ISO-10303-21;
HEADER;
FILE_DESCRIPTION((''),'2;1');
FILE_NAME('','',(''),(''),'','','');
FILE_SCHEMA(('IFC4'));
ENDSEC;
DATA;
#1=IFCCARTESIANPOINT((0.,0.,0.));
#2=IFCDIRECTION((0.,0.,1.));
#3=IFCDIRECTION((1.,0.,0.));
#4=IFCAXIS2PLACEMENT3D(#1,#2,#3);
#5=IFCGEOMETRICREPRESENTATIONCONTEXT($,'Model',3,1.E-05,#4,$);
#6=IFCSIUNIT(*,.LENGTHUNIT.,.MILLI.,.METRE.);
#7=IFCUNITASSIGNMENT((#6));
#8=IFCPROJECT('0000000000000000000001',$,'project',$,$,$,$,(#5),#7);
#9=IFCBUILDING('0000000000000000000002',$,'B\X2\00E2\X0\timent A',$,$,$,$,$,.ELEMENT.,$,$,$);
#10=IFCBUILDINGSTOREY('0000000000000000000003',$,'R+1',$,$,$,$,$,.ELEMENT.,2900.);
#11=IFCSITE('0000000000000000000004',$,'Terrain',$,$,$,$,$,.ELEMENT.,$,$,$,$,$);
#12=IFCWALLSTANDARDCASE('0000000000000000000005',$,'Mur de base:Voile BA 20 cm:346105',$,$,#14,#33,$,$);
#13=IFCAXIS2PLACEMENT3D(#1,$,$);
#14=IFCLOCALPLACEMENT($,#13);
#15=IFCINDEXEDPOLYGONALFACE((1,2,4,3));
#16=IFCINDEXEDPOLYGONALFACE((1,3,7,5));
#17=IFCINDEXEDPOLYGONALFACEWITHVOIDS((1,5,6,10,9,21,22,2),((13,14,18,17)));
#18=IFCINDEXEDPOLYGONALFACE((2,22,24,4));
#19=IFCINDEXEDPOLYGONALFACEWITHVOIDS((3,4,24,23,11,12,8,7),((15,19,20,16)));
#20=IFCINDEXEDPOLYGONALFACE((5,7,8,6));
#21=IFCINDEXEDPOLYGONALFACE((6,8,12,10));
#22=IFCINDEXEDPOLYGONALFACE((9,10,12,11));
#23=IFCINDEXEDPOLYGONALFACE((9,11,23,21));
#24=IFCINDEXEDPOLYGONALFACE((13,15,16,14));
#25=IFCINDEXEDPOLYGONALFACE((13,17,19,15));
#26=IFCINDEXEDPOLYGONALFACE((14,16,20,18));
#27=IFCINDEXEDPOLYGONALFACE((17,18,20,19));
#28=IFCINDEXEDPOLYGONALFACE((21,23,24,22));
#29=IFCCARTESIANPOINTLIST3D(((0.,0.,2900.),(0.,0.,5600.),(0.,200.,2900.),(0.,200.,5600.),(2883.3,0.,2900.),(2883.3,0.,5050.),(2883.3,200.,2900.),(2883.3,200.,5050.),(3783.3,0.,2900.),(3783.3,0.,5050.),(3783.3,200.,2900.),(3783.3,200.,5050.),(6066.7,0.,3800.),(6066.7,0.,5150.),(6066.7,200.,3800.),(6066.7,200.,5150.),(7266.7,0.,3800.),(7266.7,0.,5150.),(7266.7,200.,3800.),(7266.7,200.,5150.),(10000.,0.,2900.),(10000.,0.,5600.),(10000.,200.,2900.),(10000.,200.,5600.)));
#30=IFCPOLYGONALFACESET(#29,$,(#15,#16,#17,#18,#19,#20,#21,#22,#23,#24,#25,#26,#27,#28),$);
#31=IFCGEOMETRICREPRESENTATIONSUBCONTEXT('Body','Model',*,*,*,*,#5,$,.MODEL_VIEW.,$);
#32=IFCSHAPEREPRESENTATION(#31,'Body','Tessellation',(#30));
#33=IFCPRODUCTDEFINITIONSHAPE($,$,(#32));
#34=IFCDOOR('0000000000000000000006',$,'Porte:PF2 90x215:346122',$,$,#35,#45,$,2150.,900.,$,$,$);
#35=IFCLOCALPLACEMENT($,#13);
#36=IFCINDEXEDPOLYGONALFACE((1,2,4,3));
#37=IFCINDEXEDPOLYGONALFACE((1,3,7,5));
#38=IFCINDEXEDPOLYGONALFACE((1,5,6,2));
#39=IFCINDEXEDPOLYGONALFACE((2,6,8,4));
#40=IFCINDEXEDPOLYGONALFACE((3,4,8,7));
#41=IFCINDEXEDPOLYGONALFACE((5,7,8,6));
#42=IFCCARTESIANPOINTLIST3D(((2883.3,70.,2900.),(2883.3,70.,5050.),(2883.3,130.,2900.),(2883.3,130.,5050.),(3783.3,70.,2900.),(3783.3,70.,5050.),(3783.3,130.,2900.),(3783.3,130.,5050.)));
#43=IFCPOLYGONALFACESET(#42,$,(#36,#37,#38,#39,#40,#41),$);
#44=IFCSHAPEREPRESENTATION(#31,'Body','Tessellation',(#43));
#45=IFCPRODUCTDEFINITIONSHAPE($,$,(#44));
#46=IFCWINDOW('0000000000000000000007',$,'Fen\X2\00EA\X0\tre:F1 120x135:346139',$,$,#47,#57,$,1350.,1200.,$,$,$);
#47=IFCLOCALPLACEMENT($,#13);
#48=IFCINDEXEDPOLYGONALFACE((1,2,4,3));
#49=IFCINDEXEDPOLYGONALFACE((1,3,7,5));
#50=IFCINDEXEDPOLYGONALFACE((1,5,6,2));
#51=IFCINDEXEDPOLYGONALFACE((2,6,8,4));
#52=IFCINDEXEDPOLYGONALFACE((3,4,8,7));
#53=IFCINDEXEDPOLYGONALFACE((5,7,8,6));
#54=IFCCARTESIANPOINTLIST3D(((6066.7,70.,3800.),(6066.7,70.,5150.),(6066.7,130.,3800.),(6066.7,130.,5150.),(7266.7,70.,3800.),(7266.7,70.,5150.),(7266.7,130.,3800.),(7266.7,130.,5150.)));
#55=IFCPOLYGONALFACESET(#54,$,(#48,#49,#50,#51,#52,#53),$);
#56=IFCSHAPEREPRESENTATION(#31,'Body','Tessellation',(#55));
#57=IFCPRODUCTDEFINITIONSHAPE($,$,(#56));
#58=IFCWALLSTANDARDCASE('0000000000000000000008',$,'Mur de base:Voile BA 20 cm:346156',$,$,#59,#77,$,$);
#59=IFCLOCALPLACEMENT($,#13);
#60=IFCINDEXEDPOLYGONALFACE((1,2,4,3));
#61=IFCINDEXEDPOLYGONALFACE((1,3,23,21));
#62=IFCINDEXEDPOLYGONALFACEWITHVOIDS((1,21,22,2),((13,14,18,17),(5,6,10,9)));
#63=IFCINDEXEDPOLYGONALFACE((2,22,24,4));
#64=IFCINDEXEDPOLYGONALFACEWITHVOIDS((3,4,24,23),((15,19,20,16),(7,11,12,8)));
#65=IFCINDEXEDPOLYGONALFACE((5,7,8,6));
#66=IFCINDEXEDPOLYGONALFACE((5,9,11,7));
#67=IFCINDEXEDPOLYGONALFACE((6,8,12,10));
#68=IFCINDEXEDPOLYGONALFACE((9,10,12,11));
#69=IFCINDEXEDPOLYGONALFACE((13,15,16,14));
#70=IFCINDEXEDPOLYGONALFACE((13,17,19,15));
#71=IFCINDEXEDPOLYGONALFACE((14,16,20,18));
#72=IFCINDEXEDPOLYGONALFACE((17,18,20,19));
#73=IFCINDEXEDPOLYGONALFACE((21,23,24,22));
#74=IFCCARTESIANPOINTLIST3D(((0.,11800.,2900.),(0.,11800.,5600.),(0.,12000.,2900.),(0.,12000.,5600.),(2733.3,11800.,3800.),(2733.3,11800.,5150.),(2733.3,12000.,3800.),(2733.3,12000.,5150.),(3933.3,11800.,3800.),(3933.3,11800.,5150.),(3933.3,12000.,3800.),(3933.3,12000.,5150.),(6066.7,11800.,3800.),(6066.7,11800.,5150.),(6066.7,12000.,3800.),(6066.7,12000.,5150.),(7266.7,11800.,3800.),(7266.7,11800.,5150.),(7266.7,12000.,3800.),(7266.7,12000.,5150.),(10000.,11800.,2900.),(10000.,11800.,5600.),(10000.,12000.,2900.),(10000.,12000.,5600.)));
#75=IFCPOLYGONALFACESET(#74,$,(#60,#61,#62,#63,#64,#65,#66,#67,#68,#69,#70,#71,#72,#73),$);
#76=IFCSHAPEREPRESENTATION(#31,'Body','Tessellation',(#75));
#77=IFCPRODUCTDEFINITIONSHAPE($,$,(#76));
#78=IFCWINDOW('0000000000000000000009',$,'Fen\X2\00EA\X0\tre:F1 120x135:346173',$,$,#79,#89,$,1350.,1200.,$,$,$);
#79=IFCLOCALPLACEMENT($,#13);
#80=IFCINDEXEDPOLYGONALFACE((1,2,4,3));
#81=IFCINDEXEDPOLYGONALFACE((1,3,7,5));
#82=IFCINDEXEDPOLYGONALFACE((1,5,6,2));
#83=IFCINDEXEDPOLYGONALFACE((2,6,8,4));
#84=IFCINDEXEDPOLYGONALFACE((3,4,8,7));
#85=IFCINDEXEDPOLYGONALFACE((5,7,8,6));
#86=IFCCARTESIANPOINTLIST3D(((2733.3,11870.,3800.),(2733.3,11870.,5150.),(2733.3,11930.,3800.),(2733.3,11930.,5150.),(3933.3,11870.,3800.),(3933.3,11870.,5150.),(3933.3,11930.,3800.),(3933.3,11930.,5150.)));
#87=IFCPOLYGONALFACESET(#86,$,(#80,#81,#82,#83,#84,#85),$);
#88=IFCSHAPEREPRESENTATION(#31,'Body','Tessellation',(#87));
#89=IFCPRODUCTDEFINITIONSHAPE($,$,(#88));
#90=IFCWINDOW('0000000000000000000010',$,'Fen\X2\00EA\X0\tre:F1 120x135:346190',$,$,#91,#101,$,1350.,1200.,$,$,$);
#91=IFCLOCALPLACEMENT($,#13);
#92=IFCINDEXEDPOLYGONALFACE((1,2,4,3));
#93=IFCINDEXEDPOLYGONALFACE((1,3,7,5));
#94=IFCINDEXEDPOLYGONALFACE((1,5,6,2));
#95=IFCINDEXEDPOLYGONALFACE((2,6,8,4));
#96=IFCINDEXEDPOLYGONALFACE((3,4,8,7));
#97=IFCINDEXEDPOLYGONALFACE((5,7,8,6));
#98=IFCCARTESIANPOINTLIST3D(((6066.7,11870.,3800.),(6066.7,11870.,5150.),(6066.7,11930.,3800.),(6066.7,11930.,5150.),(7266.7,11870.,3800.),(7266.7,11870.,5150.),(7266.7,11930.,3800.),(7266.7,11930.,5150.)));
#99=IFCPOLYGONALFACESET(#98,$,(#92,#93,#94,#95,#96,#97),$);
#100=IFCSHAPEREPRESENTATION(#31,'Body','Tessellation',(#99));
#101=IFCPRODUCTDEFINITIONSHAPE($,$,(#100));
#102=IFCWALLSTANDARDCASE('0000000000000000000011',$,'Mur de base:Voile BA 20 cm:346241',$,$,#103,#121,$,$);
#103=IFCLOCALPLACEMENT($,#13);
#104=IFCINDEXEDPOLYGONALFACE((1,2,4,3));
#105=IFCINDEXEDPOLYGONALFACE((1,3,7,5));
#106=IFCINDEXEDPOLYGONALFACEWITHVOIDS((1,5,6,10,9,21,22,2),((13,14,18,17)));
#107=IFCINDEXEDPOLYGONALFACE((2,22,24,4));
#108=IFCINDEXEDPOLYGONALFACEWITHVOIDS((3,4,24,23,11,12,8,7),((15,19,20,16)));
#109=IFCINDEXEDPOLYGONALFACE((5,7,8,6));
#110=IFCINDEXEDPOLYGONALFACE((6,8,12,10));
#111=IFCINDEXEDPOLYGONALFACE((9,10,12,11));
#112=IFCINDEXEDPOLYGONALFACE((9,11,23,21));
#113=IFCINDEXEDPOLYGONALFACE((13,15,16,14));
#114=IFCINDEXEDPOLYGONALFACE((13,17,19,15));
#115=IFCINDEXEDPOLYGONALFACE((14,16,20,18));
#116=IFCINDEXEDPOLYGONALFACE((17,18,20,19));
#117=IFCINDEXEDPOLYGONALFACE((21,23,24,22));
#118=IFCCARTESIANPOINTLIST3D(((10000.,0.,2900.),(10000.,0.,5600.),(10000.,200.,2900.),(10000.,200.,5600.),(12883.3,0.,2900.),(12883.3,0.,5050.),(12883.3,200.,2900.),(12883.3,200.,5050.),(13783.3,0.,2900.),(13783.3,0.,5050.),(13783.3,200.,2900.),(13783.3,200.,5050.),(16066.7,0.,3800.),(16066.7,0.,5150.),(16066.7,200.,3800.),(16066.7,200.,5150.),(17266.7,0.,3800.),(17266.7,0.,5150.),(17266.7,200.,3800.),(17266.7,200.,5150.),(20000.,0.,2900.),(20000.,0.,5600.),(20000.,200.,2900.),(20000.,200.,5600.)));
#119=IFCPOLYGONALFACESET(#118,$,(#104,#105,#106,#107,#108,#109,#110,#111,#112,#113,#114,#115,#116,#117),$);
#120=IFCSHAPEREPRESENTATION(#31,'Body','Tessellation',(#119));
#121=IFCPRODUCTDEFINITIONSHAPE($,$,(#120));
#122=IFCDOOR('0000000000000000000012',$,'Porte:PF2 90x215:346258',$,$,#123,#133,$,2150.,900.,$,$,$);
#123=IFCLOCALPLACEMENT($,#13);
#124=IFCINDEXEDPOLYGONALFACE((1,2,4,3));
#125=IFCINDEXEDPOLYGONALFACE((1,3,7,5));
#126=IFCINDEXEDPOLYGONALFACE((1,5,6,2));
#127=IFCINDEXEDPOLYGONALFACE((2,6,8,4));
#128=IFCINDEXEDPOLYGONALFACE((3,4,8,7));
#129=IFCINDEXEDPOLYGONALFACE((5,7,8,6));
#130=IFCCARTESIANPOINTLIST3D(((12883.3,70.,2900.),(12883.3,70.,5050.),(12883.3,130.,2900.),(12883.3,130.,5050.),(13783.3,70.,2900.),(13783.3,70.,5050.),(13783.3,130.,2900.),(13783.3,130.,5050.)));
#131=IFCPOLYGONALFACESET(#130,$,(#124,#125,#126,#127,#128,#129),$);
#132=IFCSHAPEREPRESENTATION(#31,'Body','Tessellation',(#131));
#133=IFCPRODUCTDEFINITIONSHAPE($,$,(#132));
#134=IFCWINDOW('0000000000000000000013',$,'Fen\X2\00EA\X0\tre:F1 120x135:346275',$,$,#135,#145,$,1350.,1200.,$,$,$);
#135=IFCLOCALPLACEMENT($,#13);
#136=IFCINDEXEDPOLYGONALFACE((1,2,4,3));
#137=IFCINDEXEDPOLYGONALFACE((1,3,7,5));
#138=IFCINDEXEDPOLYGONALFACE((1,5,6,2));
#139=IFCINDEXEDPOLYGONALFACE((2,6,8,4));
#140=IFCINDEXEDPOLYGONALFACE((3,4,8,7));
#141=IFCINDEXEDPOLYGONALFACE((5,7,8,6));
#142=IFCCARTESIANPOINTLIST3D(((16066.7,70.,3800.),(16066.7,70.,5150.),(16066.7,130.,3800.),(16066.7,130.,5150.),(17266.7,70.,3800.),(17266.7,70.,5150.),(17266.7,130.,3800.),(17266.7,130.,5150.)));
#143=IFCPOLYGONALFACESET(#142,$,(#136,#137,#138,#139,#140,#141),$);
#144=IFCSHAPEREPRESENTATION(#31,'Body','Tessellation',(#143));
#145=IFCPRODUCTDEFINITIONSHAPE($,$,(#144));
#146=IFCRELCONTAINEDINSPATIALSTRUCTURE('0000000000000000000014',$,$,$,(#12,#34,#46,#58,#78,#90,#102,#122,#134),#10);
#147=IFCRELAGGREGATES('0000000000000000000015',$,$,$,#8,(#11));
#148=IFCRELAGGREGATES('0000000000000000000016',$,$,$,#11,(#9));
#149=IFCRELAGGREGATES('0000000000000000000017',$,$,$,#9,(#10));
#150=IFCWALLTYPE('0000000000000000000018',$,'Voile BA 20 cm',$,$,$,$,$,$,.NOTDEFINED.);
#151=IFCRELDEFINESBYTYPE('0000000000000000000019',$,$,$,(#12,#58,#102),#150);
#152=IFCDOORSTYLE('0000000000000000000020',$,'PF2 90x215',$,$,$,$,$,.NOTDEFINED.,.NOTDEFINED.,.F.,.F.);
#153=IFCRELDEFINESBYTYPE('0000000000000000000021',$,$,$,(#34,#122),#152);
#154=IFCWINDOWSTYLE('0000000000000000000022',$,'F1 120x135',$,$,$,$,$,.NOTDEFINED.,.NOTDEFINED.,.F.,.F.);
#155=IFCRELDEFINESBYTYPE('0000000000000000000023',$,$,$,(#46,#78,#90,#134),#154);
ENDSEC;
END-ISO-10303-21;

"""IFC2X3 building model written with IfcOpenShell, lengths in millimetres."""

from ifc_helpers import new_model, si_unit, frame, frame_2d, origin_with_axes, place, context, subcontext, project, spatial, rectangle, extrude, type_object, element, fill, save


model = new_model("IFC2X3")

# Units and contexts
model_context = context("Model", 3, precision=1e-05, world=origin_with_axes())
body_context = subcontext(model_context, "Body", "Model", "MODEL_VIEW")
ifc_project = project(units=[si_unit("LENGTHUNIT", "METRE", prefix="MILLI")], contexts=[model_context])

# Site, building, storey
site = spatial("IfcSite", under=ifc_project, Name="Terrain", CompositionType="ELEMENT")
building = spatial("IfcBuilding", under=site, Name="Bâtiment A", CompositionType="ELEMENT")
storey = spatial("IfcBuildingStorey", under=building, Name="R+1", CompositionType="ELEMENT", Elevation=2900.0)

# Wall, openings, door, window
wall_type_1 = type_object("IfcWallType", Name="Voile BA 20 cm", PredefinedType="NOTDEFINED")
wall_1_placement = place(None, origin_with_axes())
wall_1 = element("IfcWallStandardCase", 1, at=wall_1_placement, inside=storey, type_object=wall_type_1, Name="Mur de base:Voile BA 20 cm:346105", context=body_context, shape_type="SweptSolid", body=[
    extrude(rectangle(XDim=10000.0, YDim=200.0, at=frame_2d((5000.0, 100.0))), frame((0.0, 0.0, 2900.0), z_axis=(0.0, 0.0, 1.0), x_axis=(1.0, 0.0, 0.0)), (0.0, 0.0, 1.0), 2700.0),
])
opening_1_placement = place(None, origin_with_axes())
opening_1 = element("IfcOpeningElement", 2, at=opening_1_placement, cuts=wall_1, context=body_context, shape_type="SweptSolid", body=[
    extrude(rectangle(XDim=900.0, YDim=320.0, at=frame_2d((3333.3, 100.0))), frame((0.0, 0.0, 2900.0), z_axis=(0.0, 0.0, 1.0), x_axis=(1.0, 0.0, 0.0)), (0.0, 0.0, 1.0), 2150.0),
])
opening_2_placement = place(None, origin_with_axes())
opening_2 = element("IfcOpeningElement", 3, at=opening_2_placement, cuts=wall_1, context=body_context, shape_type="SweptSolid", body=[
    extrude(rectangle(XDim=1200.0, YDim=320.0, at=frame_2d((6666.7, 100.0))), frame((0.0, 0.0, 3800.0), z_axis=(0.0, 0.0, 1.0), x_axis=(1.0, 0.0, 0.0)), (0.0, 0.0, 1.0), 1350.0),
])
door_style = type_object("IfcDoorStyle", Name="PF2 90x215", ConstructionType="NOTDEFINED", OperationType="NOTDEFINED", ParameterTakesPrecedence=False, Sizeable=False)
door_1_placement = place(None, origin_with_axes())
door_1 = element("IfcDoor", 4, at=door_1_placement, inside=storey, type_object=door_style, Name="Porte:PF2 90x215:346122", OverallHeight=2150.0, OverallWidth=900.0, context=body_context, shape_type="SweptSolid", body=[
    extrude(rectangle(XDim=900.0, YDim=60.0, at=frame_2d((3333.3, 100.0))), frame((0.0, 0.0, 2900.0), z_axis=(0.0, 0.0, 1.0), x_axis=(1.0, 0.0, 0.0)), (0.0, 0.0, 1.0), 2150.0),
])
fill(opening_1, door_1)
window_style = type_object("IfcWindowStyle", Name="F1 120x135", ConstructionType="NOTDEFINED", OperationType="NOTDEFINED", ParameterTakesPrecedence=False, Sizeable=False)
window_1_placement = place(None, origin_with_axes())
window_1 = element("IfcWindow", 5, at=window_1_placement, inside=storey, type_object=window_style, Name="Fenêtre:F1 120x135:346139", OverallHeight=1350.0, OverallWidth=1200.0, context=body_context, shape_type="SweptSolid", body=[
    extrude(rectangle(XDim=1200.0, YDim=60.0, at=frame_2d((6666.7, 100.0))), frame((0.0, 0.0, 3800.0), z_axis=(0.0, 0.0, 1.0), x_axis=(1.0, 0.0, 0.0)), (0.0, 0.0, 1.0), 1350.0),
])
fill(opening_2, window_1)

# Wall, openings, windows
wall_2_placement = place(None, origin_with_axes())
wall_2 = element("IfcWallStandardCase", 6, at=wall_2_placement, inside=storey, type_object=wall_type_1, Name="Mur de base:Voile BA 20 cm:346156", context=body_context, shape_type="SweptSolid", body=[
    extrude(rectangle(XDim=10000.0, YDim=200.0, at=frame_2d((5000.0, 11900.0))), frame((0.0, 0.0, 2900.0), z_axis=(0.0, 0.0, 1.0), x_axis=(1.0, 0.0, 0.0)), (0.0, 0.0, 1.0), 2700.0),
])
opening_3_placement = place(None, origin_with_axes())
opening_3 = element("IfcOpeningElement", 7, at=opening_3_placement, cuts=wall_2, context=body_context, shape_type="SweptSolid", body=[
    extrude(rectangle(XDim=1200.0, YDim=320.0, at=frame_2d((3333.3, 11900.0))), frame((0.0, 0.0, 3800.0), z_axis=(0.0, 0.0, 1.0), x_axis=(1.0, 0.0, 0.0)), (0.0, 0.0, 1.0), 1350.0),
])
opening_4_placement = place(None, origin_with_axes())
opening_4 = element("IfcOpeningElement", 8, at=opening_4_placement, cuts=wall_2, context=body_context, shape_type="SweptSolid", body=[
    extrude(rectangle(XDim=1200.0, YDim=320.0, at=frame_2d((6666.7, 11900.0))), frame((0.0, 0.0, 3800.0), z_axis=(0.0, 0.0, 1.0), x_axis=(1.0, 0.0, 0.0)), (0.0, 0.0, 1.0), 1350.0),
])
window_2_placement = place(None, origin_with_axes())
window_2 = element("IfcWindow", 9, at=window_2_placement, inside=storey, type_object=window_style, Name="Fenêtre:F1 120x135:346173", OverallHeight=1350.0, OverallWidth=1200.0, context=body_context, shape_type="SweptSolid", body=[
    extrude(rectangle(XDim=1200.0, YDim=60.0, at=frame_2d((3333.3, 11900.0))), frame((0.0, 0.0, 3800.0), z_axis=(0.0, 0.0, 1.0), x_axis=(1.0, 0.0, 0.0)), (0.0, 0.0, 1.0), 1350.0),
])
fill(opening_3, window_2)
window_3_placement = place(None, origin_with_axes())
window_3 = element("IfcWindow", 10, at=window_3_placement, inside=storey, type_object=window_style, Name="Fenêtre:F1 120x135:346190", OverallHeight=1350.0, OverallWidth=1200.0, context=body_context, shape_type="SweptSolid", body=[
    extrude(rectangle(XDim=1200.0, YDim=60.0, at=frame_2d((6666.7, 11900.0))), frame((0.0, 0.0, 3800.0), z_axis=(0.0, 0.0, 1.0), x_axis=(1.0, 0.0, 0.0)), (0.0, 0.0, 1.0), 1350.0),
])
fill(opening_4, window_3)

# Wall, openings, door, window
wall_3_placement = place(None, origin_with_axes())
wall_3 = element("IfcWallStandardCase", 11, at=wall_3_placement, inside=storey, type_object=wall_type_1, Name="Mur de base:Voile BA 20 cm:346241", context=body_context, shape_type="SweptSolid", body=[
    extrude(rectangle(XDim=10000.0, YDim=200.0, at=frame_2d((15000.0, 100.0))), frame((0.0, 0.0, 2900.0), z_axis=(0.0, 0.0, 1.0), x_axis=(1.0, 0.0, 0.0)), (0.0, 0.0, 1.0), 2700.0),
])
opening_5_placement = place(None, origin_with_axes())
opening_5 = element("IfcOpeningElement", 12, at=opening_5_placement, cuts=wall_3, context=body_context, shape_type="SweptSolid", body=[
    extrude(rectangle(XDim=900.0, YDim=320.0, at=frame_2d((13333.3, 100.0))), frame((0.0, 0.0, 2900.0), z_axis=(0.0, 0.0, 1.0), x_axis=(1.0, 0.0, 0.0)), (0.0, 0.0, 1.0), 2150.0),
])
opening_6_placement = place(None, origin_with_axes())
opening_6 = element("IfcOpeningElement", 13, at=opening_6_placement, cuts=wall_3, context=body_context, shape_type="SweptSolid", body=[
    extrude(rectangle(XDim=1200.0, YDim=320.0, at=frame_2d((16666.7, 100.0))), frame((0.0, 0.0, 3800.0), z_axis=(0.0, 0.0, 1.0), x_axis=(1.0, 0.0, 0.0)), (0.0, 0.0, 1.0), 1350.0),
])
door_2_placement = place(None, origin_with_axes())
door_2 = element("IfcDoor", 14, at=door_2_placement, inside=storey, type_object=door_style, Name="Porte:PF2 90x215:346258", OverallHeight=2150.0, OverallWidth=900.0, context=body_context, shape_type="SweptSolid", body=[
    extrude(rectangle(XDim=900.0, YDim=60.0, at=frame_2d((13333.3, 100.0))), frame((0.0, 0.0, 2900.0), z_axis=(0.0, 0.0, 1.0), x_axis=(1.0, 0.0, 0.0)), (0.0, 0.0, 1.0), 2150.0),
])
fill(opening_5, door_2)
window_4_placement = place(None, origin_with_axes())
window_4 = element("IfcWindow", 15, at=window_4_placement, inside=storey, type_object=window_style, Name="Fenêtre:F1 120x135:346275", OverallHeight=1350.0, OverallWidth=1200.0, context=body_context, shape_type="SweptSolid", body=[
    extrude(rectangle(XDim=1200.0, YDim=60.0, at=frame_2d((16666.7, 100.0))), frame((0.0, 0.0, 3800.0), z_axis=(0.0, 0.0, 1.0), x_axis=(1.0, 0.0, 0.0)), (0.0, 0.0, 1.0), 1350.0),
])
fill(opening_6, window_4)

save(model, "model.ifc")
